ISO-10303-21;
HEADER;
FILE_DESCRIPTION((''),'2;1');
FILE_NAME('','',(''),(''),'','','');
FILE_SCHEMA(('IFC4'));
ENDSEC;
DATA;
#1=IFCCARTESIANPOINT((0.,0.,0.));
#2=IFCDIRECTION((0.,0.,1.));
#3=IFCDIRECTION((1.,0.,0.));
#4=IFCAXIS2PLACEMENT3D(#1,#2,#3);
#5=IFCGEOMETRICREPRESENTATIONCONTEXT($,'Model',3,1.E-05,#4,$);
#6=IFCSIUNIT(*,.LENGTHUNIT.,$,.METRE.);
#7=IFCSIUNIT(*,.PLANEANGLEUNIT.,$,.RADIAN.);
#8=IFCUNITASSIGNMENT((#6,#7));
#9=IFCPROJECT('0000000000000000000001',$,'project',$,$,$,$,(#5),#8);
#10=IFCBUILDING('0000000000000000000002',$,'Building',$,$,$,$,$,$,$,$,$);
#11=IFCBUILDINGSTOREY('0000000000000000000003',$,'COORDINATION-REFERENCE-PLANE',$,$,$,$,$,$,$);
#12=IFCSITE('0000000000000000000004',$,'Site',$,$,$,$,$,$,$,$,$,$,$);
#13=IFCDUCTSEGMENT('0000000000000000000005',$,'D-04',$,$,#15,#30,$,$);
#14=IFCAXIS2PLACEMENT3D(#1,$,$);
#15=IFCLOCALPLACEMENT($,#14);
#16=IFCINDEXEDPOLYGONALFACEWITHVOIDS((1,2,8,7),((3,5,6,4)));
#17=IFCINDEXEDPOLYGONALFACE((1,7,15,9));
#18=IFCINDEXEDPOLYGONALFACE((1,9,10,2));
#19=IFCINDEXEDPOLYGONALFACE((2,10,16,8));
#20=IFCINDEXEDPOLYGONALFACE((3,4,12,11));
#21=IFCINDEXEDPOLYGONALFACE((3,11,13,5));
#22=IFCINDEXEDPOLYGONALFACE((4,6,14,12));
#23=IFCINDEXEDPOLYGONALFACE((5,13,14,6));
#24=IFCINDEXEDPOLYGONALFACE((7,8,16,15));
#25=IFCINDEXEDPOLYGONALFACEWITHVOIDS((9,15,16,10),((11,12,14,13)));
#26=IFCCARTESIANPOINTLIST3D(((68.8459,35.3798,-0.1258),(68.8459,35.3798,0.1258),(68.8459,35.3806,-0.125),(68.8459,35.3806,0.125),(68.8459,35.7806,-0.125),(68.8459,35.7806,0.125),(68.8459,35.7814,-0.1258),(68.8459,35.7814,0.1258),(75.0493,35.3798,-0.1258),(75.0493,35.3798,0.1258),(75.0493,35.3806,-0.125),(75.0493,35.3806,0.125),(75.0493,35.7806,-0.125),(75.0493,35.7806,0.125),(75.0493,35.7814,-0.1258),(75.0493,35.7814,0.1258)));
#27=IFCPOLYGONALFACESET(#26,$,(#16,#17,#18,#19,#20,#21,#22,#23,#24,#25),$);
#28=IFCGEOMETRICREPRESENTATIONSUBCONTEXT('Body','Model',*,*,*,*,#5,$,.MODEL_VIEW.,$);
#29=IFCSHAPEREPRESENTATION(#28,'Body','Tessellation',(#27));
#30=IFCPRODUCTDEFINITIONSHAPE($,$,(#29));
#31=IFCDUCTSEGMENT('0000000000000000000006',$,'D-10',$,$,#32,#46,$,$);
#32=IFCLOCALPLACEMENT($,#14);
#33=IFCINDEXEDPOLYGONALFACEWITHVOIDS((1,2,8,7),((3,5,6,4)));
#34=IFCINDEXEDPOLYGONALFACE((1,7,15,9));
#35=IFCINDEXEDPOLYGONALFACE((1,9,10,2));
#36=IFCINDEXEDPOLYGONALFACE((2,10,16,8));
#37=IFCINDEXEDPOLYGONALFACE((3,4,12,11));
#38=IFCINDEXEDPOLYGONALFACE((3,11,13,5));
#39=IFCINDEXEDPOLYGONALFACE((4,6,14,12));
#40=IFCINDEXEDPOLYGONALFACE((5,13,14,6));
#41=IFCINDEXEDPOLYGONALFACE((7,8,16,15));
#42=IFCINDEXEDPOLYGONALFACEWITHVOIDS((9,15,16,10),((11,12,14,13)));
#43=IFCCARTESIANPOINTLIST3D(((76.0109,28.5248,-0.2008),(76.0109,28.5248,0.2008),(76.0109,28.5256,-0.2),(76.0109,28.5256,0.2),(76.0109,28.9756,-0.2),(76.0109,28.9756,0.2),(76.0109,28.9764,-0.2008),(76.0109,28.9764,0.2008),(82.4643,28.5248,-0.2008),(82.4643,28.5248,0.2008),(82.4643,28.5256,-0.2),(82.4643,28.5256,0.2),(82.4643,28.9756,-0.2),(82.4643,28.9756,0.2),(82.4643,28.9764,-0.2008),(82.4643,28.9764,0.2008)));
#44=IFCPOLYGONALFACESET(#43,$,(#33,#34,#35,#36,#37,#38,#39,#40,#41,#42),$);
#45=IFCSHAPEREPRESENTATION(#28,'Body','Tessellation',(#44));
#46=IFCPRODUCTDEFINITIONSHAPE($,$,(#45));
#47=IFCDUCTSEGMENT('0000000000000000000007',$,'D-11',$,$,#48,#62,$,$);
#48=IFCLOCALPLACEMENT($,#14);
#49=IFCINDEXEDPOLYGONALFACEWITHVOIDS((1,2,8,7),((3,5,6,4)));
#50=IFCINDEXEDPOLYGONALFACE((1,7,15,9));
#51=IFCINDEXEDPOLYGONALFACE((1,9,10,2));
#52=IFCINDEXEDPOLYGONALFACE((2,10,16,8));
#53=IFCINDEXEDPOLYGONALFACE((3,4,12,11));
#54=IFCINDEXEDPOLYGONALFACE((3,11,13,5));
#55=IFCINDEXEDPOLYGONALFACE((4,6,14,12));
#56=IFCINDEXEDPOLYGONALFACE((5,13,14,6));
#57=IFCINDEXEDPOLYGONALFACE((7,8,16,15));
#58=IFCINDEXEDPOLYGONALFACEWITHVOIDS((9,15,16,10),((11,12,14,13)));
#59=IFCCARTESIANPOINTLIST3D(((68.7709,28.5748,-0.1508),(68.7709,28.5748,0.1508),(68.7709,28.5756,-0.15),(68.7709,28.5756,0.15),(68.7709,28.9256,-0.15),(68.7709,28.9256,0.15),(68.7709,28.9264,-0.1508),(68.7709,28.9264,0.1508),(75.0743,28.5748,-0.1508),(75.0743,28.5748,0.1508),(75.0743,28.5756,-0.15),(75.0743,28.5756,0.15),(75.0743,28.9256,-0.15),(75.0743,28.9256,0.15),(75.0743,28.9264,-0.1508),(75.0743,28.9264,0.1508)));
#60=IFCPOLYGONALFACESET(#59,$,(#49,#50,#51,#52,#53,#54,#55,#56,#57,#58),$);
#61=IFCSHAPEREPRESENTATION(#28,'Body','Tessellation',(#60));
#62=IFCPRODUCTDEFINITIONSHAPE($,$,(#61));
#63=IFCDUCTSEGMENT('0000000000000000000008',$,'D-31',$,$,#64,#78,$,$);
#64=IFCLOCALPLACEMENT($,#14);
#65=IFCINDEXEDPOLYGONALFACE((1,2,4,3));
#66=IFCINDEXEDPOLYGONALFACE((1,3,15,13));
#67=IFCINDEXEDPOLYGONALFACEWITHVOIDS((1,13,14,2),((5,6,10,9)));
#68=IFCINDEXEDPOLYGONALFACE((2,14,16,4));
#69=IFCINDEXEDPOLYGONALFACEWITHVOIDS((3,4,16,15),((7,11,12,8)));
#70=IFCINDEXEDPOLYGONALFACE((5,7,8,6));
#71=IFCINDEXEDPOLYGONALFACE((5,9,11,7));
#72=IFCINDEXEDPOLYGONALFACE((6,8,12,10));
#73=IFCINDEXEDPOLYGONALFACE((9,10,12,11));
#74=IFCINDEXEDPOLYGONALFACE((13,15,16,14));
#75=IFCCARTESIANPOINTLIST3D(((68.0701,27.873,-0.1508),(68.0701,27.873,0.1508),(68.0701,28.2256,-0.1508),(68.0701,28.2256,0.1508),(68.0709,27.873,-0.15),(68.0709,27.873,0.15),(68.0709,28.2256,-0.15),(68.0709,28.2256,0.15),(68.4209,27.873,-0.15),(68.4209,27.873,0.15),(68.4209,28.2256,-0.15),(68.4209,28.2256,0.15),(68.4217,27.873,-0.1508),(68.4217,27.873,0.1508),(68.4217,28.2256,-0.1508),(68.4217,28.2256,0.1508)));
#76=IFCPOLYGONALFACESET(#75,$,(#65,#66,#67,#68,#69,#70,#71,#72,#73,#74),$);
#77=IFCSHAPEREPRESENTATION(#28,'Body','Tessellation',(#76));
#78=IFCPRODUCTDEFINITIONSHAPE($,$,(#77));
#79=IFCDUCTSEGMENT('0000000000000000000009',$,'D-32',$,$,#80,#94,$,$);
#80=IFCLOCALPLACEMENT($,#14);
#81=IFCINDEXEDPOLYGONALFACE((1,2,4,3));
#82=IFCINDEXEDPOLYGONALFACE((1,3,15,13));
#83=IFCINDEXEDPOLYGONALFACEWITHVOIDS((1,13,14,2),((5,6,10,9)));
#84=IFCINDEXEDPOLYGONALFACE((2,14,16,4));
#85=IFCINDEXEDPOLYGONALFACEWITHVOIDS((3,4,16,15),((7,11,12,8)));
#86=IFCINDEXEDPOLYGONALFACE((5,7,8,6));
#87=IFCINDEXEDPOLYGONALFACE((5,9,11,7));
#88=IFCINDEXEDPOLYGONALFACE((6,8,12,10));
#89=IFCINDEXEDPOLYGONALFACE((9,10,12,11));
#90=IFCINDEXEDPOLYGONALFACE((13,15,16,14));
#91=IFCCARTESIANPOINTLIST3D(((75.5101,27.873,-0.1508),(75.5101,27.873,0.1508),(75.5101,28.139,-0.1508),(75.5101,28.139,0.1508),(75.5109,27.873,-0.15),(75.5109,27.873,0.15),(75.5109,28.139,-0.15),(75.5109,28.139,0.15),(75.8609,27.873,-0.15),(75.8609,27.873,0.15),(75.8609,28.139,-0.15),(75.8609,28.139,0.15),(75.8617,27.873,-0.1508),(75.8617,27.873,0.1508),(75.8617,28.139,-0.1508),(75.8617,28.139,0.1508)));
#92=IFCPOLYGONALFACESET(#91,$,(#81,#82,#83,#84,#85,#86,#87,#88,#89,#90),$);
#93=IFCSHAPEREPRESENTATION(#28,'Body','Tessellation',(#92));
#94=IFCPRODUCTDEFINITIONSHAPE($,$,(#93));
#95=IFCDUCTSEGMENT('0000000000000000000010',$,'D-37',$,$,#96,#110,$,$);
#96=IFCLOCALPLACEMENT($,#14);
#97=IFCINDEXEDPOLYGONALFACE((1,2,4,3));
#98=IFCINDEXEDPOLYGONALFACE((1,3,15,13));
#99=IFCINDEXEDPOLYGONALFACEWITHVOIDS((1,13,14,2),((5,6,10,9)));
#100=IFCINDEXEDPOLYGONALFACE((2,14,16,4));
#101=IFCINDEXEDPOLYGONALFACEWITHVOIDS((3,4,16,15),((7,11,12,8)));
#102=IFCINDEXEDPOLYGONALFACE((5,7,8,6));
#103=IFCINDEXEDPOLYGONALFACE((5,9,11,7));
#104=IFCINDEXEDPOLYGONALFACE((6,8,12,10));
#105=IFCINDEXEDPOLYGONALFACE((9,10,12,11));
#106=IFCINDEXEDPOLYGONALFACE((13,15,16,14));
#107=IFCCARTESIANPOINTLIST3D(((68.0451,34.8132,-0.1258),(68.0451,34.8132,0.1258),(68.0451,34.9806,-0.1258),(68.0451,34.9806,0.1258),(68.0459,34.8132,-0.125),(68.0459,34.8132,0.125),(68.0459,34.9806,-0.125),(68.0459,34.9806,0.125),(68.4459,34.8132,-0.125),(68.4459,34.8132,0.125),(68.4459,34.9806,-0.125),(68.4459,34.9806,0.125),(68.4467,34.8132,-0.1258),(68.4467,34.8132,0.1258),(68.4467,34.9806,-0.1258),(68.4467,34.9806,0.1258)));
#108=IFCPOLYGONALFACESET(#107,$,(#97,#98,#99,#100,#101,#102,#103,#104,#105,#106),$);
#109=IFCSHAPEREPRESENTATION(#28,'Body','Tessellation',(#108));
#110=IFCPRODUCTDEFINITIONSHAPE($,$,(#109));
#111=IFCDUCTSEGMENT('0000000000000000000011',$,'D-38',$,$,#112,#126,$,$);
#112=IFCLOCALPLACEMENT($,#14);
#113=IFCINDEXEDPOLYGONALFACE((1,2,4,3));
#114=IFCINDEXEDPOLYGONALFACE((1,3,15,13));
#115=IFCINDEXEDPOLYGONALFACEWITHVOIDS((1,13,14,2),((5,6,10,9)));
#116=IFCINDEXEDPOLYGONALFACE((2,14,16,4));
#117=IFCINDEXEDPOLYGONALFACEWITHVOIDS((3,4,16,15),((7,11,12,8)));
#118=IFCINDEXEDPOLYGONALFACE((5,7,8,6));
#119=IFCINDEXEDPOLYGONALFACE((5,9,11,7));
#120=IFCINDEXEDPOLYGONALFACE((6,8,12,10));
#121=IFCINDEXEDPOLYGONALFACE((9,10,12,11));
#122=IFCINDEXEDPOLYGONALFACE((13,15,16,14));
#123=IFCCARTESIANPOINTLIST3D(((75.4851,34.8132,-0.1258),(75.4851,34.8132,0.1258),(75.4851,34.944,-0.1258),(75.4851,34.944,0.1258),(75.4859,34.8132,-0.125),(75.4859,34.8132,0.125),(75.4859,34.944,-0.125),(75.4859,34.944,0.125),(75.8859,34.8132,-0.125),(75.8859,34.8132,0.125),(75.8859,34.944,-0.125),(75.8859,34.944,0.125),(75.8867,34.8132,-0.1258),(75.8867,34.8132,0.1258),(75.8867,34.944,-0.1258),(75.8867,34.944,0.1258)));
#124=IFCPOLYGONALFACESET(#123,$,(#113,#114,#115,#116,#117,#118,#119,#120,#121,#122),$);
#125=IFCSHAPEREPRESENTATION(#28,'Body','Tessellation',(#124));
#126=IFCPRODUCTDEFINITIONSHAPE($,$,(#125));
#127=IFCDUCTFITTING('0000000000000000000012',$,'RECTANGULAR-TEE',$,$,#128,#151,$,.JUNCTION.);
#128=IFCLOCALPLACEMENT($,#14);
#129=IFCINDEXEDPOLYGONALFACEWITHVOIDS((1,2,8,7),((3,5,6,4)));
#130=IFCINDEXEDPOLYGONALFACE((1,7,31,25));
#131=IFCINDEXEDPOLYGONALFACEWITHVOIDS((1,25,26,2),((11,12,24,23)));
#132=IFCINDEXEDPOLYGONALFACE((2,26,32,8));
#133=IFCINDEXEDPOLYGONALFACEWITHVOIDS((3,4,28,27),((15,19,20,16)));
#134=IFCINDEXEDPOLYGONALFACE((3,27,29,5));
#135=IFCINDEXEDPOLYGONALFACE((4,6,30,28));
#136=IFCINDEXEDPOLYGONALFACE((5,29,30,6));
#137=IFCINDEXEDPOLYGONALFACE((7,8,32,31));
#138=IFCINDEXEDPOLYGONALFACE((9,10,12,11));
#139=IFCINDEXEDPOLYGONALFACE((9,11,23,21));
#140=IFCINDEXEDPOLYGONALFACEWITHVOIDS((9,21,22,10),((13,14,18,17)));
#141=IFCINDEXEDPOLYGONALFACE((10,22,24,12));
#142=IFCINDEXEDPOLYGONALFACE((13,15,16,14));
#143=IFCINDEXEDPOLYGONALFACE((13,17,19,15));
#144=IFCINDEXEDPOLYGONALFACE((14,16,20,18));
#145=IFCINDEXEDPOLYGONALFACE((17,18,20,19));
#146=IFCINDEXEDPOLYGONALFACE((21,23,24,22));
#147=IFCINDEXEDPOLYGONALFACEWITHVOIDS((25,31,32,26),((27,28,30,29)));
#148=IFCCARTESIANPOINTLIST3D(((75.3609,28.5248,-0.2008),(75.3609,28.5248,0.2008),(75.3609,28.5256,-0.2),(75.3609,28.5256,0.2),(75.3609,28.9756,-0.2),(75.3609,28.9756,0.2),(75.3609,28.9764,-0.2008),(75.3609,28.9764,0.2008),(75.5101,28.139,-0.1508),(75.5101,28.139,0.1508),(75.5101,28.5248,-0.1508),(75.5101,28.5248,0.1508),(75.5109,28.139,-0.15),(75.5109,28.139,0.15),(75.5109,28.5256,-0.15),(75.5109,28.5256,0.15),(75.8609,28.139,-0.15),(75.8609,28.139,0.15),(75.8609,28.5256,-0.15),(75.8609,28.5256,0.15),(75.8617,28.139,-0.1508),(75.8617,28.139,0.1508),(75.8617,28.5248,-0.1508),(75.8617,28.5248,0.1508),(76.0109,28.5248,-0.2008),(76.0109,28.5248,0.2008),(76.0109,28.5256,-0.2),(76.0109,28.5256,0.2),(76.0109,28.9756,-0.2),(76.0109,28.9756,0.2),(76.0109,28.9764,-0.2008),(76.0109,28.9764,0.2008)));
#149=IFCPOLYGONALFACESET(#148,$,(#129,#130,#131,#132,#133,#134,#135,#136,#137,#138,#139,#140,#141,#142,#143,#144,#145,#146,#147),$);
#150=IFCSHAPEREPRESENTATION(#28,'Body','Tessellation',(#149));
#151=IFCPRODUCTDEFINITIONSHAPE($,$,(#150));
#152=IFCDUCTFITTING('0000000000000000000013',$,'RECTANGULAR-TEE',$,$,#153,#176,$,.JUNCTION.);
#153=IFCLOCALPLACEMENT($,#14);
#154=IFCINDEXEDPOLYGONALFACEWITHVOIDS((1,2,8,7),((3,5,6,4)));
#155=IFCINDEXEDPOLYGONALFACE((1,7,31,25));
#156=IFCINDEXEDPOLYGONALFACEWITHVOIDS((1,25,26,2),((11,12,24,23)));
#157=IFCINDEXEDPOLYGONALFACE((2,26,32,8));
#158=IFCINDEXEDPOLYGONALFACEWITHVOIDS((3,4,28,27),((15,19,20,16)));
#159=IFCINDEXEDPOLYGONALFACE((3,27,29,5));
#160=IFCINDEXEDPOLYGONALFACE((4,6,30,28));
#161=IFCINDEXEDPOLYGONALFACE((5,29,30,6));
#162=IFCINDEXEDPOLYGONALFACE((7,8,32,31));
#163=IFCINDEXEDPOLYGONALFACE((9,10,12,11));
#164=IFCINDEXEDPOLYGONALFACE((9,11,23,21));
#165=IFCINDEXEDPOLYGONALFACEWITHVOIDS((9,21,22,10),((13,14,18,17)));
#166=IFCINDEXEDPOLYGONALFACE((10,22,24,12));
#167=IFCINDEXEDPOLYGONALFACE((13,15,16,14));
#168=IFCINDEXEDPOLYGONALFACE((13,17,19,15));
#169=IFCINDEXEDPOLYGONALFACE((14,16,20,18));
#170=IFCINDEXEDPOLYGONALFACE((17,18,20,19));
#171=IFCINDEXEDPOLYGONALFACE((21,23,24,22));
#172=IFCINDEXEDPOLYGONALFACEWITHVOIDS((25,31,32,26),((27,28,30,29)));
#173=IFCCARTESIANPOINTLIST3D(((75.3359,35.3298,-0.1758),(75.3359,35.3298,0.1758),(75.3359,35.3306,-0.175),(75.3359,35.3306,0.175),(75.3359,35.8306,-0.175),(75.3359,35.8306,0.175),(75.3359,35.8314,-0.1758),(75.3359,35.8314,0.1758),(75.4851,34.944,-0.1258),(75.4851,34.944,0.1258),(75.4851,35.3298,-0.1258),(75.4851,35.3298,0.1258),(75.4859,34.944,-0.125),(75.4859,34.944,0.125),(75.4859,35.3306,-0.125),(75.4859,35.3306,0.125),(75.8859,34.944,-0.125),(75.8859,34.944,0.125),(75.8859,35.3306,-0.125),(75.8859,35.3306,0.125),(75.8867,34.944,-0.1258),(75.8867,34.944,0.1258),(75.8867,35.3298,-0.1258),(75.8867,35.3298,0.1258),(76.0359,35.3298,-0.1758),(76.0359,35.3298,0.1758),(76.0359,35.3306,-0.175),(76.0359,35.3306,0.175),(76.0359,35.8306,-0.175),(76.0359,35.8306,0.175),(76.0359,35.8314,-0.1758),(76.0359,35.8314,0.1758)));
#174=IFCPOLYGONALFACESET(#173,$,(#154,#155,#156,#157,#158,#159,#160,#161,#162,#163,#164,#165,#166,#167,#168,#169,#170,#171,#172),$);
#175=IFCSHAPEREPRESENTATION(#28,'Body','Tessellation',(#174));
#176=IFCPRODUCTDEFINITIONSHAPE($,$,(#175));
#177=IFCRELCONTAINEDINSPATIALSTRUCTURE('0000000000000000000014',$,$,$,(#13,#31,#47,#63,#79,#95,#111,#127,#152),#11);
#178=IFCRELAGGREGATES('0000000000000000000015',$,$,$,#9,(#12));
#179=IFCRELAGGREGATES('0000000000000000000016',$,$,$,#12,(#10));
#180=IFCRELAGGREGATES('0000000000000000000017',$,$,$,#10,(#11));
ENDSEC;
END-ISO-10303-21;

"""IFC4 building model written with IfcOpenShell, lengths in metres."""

from ifc_helpers import new_model, si_unit, frame, origin, origin_with_axes, place, context, subcontext, project, spatial, rectangle, hollow_rectangle, extrude, boolean, element, save


model = new_model("IFC4")

# Units and contexts
model_context = context("Model", 3, precision=1e-05, world=origin_with_axes())
body_context_1 = subcontext(model_context, "Body", "Model", "MODEL_VIEW")
ifc_project = project(units=[si_unit("LENGTHUNIT", "METRE"), si_unit("PLANEANGLEUNIT", "RADIAN")], contexts=[model_context])

# Site, building, storey
site = spatial("IfcSite", under=ifc_project, Name="Site")
building = spatial("IfcBuilding", under=site, Name="Building")
storey = spatial("IfcBuildingStorey", under=building, Name="COORDINATION-REFERENCE-PLANE")

# Duct segments
duct_segment_1_placement = place(None, frame((68.8459, 35.5806, 0.0), z_axis=(1.0, 0.0, 0.0), x_axis=(0.0, 1.0, 0.0)))
element("IfcDuctSegment", 1, at=duct_segment_1_placement, inside=storey, Name="D-04", context=body_context_1, shape_type="SweptSolid", body=[
    extrude(hollow_rectangle(XDim=0.4016, YDim=0.2516, WallThickness=0.0008), origin(), (0.0, 0.0, 1.0), 6.2034),
])
duct_segment_2_placement = place(None, frame((76.0109, 28.7506, 0.0), z_axis=(1.0, 0.0, 0.0), x_axis=(0.0, 1.0, 0.0)))
element("IfcDuctSegment", 2, at=duct_segment_2_placement, inside=storey, Name="D-10", context=body_context_1, shape_type="SweptSolid", body=[
    extrude(hollow_rectangle(XDim=0.4516, YDim=0.4016, WallThickness=0.0008), origin(), (0.0, 0.0, 1.0), 6.4534),
])
duct_segment_3_placement = place(None, frame((68.7709, 28.7506, 0.0), z_axis=(1.0, 0.0, 0.0), x_axis=(0.0, 1.0, 0.0)))
element("IfcDuctSegment", 3, at=duct_segment_3_placement, inside=storey, Name="D-11", context=body_context_1, shape_type="SweptSolid", body=[
    extrude(hollow_rectangle(XDim=0.3516, YDim=0.3016, WallThickness=0.0008), origin(), (0.0, 0.0, 1.0), 6.3034),
])
duct_segment_4_placement = place(None, frame((68.2459, 27.873, 0.0), z_axis=(0.0, 1.0, 0.0), x_axis=(1.0, 0.0, 0.0)))
element("IfcDuctSegment", 4, at=duct_segment_4_placement, inside=storey, Name="D-31", context=body_context_1, shape_type="SweptSolid", body=[
    extrude(hollow_rectangle(XDim=0.3516, YDim=0.3016, WallThickness=0.0008), origin(), (0.0, 0.0, 1.0), 0.3526),
])
duct_segment_5_placement = place(None, frame((75.6859, 27.873, 0.0), z_axis=(0.0, 1.0, 0.0), x_axis=(1.0, 0.0, 0.0)))
element("IfcDuctSegment", 5, at=duct_segment_5_placement, inside=storey, Name="D-32", context=body_context_1, shape_type="SweptSolid", body=[
    extrude(hollow_rectangle(XDim=0.3516, YDim=0.3016, WallThickness=0.0008), origin(), (0.0, 0.0, 1.0), 0.266),
])
duct_segment_6_placement = place(None, frame((68.2459, 34.8132, 0.0), z_axis=(0.0, 1.0, 0.0), x_axis=(1.0, 0.0, 0.0)))
element("IfcDuctSegment", 6, at=duct_segment_6_placement, inside=storey, Name="D-37", context=body_context_1, shape_type="SweptSolid", body=[
    extrude(hollow_rectangle(XDim=0.4016, YDim=0.2516, WallThickness=0.0008), origin(), (0.0, 0.0, 1.0), 0.1673),
])
duct_segment_7_placement = place(None, frame((75.6859, 34.8132, 0.0), z_axis=(0.0, 1.0, 0.0), x_axis=(1.0, 0.0, 0.0)))
element("IfcDuctSegment", 7, at=duct_segment_7_placement, inside=storey, Name="D-38", context=body_context_1, shape_type="SweptSolid", body=[
    extrude(hollow_rectangle(XDim=0.4016, YDim=0.2516, WallThickness=0.0008), origin(), (0.0, 0.0, 1.0), 0.1307),
])

# Duct fittings
duct_fitting_1_placement = place(None, frame((75.6859, 28.7506, 0.0), z_axis=(-1.0, 0.0, 0.0), x_axis=(0.0, -1.0, 0.0)))
solid_1 = boolean("UNION", extrude(rectangle(XDim=0.45, YDim=0.4), frame((0.0, 0.0, -0.325), z_axis=(0.0, 0.0, 1.0), x_axis=(1.0, 0.0, 0.0)), (0.0, 0.0, 1.0), 0.65), extrude(rectangle(XDim=0.35, YDim=0.3), frame((0.0, 0.0, 0.0), z_axis=(1.0, 0.0, 0.0), x_axis=(0.0, 0.0, -1.0)), (0.0, 0.0, 1.0), 0.6116))
element("IfcDuctFitting", 8, at=duct_fitting_1_placement, inside=storey, Name="RECTANGULAR-TEE", PredefinedType="JUNCTION", context=body_context_1, shape_type="CSG", body=[
    boolean("DIFFERENCE", boolean("UNION", extrude(rectangle(XDim=0.4516, YDim=0.4016), frame((0.0, 0.0, -0.325), z_axis=(0.0, 0.0, 1.0), x_axis=(1.0, 0.0, 0.0)), (0.0, 0.0, 1.0), 0.65), extrude(rectangle(XDim=0.3516, YDim=0.3016), frame((0.0, 0.0, 0.0), z_axis=(1.0, 0.0, 0.0), x_axis=(0.0, 0.0, -1.0)), (0.0, 0.0, 1.0), 0.6116)), solid_1),
])
duct_fitting_2_placement = place(None, frame((75.6859, 35.5806, 0.0), z_axis=(-1.0, 0.0, 0.0), x_axis=(0.0, -1.0, 0.0)))
solid_2 = boolean("UNION", extrude(rectangle(XDim=0.5, YDim=0.35), frame((0.0, 0.0, -0.35), z_axis=(0.0, 0.0, 1.0), x_axis=(1.0, 0.0, 0.0)), (0.0, 0.0, 1.0), 0.7), extrude(rectangle(XDim=0.4, YDim=0.25), frame((0.0, 0.0, 0.0), z_axis=(1.0, 0.0, 0.0), x_axis=(0.0, 0.0, -1.0)), (0.0, 0.0, 1.0), 0.6366))
element("IfcDuctFitting", 9, at=duct_fitting_2_placement, inside=storey, Name="RECTANGULAR-TEE", PredefinedType="JUNCTION", context=body_context_1, shape_type="CSG", body=[
    boolean("DIFFERENCE", boolean("UNION", extrude(rectangle(XDim=0.5016, YDim=0.3516), frame((0.0, 0.0, -0.35), z_axis=(0.0, 0.0, 1.0), x_axis=(1.0, 0.0, 0.0)), (0.0, 0.0, 1.0), 0.7), extrude(rectangle(XDim=0.4016, YDim=0.2516), frame((0.0, 0.0, 0.0), z_axis=(1.0, 0.0, 0.0), x_axis=(0.0, 0.0, -1.0)), (0.0, 0.0, 1.0), 0.6366)), solid_2),
])

save(model, "model.ifc")
